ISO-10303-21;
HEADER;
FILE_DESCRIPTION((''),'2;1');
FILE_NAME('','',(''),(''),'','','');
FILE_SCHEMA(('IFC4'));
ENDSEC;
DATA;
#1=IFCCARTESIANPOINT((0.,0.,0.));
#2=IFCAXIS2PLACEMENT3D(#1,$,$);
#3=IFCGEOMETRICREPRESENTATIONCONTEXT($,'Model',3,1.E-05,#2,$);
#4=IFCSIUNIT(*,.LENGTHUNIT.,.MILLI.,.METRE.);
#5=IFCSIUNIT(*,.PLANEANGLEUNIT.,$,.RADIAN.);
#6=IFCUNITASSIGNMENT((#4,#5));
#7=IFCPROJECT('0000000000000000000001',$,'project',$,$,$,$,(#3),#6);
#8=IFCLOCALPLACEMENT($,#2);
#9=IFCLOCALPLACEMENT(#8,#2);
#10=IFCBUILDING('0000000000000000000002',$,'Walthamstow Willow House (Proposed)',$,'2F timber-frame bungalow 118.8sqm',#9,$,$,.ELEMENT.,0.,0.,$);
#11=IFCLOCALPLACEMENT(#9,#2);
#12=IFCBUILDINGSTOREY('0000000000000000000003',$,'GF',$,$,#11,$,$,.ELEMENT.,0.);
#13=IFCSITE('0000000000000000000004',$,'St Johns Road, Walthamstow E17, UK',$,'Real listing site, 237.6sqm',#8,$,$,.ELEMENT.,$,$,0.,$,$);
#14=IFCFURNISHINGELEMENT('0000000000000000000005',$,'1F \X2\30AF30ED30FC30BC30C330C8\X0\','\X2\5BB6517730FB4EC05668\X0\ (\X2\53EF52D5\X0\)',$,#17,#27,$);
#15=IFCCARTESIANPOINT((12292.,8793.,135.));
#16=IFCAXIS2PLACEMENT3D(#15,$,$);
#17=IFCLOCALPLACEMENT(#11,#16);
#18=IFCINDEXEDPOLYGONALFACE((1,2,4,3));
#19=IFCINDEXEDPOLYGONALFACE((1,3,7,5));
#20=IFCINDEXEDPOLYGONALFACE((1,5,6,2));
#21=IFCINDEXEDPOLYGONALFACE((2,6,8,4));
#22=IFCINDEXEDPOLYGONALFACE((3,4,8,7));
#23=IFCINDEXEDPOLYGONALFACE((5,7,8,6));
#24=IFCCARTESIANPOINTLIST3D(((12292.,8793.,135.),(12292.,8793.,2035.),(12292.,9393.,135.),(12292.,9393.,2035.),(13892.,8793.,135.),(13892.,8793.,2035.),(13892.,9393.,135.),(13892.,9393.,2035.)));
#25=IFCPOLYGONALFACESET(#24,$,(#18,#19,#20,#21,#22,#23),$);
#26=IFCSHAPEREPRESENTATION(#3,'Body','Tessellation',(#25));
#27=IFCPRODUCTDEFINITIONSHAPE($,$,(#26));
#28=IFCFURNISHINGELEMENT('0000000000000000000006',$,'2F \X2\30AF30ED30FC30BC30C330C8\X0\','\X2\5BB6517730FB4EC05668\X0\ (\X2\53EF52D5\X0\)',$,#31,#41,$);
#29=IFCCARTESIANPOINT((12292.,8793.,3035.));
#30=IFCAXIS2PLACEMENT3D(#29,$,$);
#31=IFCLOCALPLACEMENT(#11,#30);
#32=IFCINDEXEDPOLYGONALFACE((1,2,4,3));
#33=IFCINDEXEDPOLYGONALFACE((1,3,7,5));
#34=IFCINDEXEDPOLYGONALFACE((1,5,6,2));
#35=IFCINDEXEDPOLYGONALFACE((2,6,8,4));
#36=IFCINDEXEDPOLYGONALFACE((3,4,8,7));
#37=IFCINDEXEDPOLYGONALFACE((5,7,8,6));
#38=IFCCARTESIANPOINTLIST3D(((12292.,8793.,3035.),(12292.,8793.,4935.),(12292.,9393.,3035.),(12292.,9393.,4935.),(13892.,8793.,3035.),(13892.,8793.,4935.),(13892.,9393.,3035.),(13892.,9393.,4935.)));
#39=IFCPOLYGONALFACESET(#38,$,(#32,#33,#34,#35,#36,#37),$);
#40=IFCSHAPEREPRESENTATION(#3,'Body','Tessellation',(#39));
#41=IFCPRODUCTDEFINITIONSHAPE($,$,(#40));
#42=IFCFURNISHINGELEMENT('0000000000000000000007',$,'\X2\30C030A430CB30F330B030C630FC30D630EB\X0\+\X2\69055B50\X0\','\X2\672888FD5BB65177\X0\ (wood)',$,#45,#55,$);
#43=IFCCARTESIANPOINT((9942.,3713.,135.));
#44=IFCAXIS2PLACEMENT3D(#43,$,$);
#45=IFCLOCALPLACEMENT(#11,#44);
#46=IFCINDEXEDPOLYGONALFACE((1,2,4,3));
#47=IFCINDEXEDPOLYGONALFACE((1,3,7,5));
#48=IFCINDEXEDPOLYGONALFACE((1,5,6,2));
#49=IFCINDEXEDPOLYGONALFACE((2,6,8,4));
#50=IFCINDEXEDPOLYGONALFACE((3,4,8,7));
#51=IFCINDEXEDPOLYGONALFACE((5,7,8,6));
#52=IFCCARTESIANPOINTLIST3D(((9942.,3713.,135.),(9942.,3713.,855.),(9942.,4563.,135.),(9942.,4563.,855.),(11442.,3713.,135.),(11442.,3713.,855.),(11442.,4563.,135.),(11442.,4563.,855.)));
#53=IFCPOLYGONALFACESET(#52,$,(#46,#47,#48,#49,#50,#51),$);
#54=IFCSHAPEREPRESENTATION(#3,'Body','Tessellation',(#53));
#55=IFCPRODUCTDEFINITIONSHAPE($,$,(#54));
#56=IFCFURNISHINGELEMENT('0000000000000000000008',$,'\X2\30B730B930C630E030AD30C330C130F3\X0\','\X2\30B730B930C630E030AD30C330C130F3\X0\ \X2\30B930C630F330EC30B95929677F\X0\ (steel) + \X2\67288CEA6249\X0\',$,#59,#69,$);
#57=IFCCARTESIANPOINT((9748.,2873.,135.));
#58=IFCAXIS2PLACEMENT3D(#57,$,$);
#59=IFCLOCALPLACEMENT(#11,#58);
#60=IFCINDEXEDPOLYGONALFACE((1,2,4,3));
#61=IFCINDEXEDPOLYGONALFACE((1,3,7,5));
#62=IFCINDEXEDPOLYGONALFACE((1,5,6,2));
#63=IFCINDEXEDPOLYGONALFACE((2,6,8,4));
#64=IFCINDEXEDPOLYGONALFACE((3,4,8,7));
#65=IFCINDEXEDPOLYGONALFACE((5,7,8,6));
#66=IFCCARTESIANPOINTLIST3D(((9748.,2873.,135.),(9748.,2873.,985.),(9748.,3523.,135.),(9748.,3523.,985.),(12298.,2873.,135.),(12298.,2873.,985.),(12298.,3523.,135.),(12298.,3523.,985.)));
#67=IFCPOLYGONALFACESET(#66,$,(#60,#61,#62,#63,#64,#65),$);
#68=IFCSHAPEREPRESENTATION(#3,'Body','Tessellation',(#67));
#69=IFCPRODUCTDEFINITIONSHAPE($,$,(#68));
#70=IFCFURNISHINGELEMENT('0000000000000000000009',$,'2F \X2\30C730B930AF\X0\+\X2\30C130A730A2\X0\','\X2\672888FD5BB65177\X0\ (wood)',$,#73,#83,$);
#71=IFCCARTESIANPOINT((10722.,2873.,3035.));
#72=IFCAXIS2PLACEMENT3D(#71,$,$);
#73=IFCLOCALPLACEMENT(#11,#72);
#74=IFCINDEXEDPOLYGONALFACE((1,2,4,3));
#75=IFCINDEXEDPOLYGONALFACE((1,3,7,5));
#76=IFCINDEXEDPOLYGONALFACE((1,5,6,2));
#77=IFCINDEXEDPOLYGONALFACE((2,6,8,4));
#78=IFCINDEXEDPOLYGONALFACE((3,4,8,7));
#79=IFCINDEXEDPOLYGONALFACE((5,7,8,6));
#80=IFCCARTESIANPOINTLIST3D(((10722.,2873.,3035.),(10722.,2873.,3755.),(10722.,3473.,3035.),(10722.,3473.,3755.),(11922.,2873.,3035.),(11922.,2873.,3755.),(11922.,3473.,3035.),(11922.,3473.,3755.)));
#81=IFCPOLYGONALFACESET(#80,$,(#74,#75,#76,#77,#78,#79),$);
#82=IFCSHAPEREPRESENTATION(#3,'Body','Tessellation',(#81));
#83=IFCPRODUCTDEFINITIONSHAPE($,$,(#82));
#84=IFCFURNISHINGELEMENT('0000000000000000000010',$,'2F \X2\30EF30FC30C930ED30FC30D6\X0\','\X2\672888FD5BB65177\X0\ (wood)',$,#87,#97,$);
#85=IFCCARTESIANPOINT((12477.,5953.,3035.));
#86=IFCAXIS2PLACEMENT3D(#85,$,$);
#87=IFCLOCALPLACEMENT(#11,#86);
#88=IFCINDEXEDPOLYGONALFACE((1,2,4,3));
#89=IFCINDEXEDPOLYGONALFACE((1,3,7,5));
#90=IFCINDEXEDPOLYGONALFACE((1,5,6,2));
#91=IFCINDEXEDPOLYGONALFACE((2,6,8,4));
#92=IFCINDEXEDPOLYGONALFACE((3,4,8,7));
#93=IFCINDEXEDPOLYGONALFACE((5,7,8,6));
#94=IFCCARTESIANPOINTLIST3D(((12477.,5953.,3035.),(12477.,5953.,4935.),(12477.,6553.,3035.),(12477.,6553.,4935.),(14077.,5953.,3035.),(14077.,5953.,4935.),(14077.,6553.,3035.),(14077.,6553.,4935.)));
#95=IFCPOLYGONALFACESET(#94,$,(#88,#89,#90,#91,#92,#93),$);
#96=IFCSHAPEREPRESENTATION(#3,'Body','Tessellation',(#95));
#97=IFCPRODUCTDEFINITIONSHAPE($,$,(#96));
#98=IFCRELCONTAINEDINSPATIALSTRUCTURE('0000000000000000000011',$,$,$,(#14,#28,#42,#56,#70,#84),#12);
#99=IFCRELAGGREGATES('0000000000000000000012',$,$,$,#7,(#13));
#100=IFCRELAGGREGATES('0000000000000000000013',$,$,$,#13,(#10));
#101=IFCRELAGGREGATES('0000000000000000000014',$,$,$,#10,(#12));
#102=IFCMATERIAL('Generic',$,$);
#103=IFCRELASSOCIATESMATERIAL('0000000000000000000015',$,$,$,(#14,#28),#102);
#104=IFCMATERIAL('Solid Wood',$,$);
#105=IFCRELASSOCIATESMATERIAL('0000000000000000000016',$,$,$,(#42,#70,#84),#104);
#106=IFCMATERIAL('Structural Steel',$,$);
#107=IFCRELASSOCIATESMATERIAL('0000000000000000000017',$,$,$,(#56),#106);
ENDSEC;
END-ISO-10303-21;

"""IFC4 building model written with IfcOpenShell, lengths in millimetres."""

from ifc_helpers import new_model, si_unit, frame, frame_2d, origin, place, context, project, spatial, rectangle, extrude, material, element, save


model = new_model("IFC4")

# Units and contexts
model_context = context("Model", 3, precision=1e-05, world=origin())
ifc_project = project(units=[si_unit("LENGTHUNIT", "METRE", prefix="MILLI"), si_unit("PLANEANGLEUNIT", "RADIAN")], contexts=[model_context])

# Site, building, storey
site_placement = place(None, origin())
site = spatial("IfcSite", under=ifc_project, at=site_placement, Name="St Johns Road, Walthamstow E17, UK", ObjectType="Real listing site, 237.6sqm", CompositionType="ELEMENT", RefElevation=0.0)
building_placement = place(site_placement, origin())
building = spatial("IfcBuilding", under=site, at=building_placement, Name="Walthamstow Willow House (Proposed)", ObjectType="2F timber-frame bungalow 118.8sqm", CompositionType="ELEMENT", ElevationOfRefHeight=0.0, ElevationOfTerrain=0.0)
storey_placement = place(building_placement, origin())
storey = spatial("IfcBuildingStorey", under=building, at=storey_placement, Name="GF", CompositionType="ELEMENT", Elevation=0.0)

# Shared definitions
ifc_material_1 = material(Name="Solid Wood")

# Shared definitions
ifc_material_2 = material(Name="Generic")

# Furnishing elements
furnishing_1_placement = place(storey_placement, frame((12292.0, 8793.0, 135.0)))
element("IfcFurnishingElement", 1, at=furnishing_1_placement, inside=storey, material=ifc_material_2, Name="1F クローゼット", Description="家具・什器 (可動)", context=model_context, shape_type="SweptSolid", body=[
    extrude(rectangle(XDim=1600.0, YDim=600.0, at=frame_2d((800.0, 300.0))), frame((12292.0, 8793.0, 135.0)), (0.0, 0.0, 1.0), 1900.0),
])
furnishing_2_placement = place(storey_placement, frame((12292.0, 8793.0, 3035.0)))
element("IfcFurnishingElement", 2, at=furnishing_2_placement, inside=storey, material=ifc_material_2, Name="2F クローゼット", Description="家具・什器 (可動)", context=model_context, shape_type="SweptSolid", body=[
    extrude(rectangle(XDim=1600.0, YDim=600.0, at=frame_2d((800.0, 300.0))), frame((12292.0, 8793.0, 3035.0)), (0.0, 0.0, 1.0), 1900.0),
])
furnishing_3_placement = place(storey_placement, frame((9942.0, 3713.0, 135.0)))
element("IfcFurnishingElement", 3, at=furnishing_3_placement, inside=storey, material=ifc_material_1, Name="ダイニングテーブル+椅子", Description="木製家具 (wood)", context=model_context, shape_type="SweptSolid", body=[
    extrude(rectangle(XDim=1500.0, YDim=850.0, at=frame_2d((750.0, 425.0))), frame((9942.0, 3713.0, 135.0)), (0.0, 0.0, 1.0), 720.0),
])
ifc_material_3 = material(Name="Structural Steel")
furnishing_4_placement = place(storey_placement, frame((9748.0, 2873.0, 135.0)))
element("IfcFurnishingElement", 4, at=furnishing_4_placement, inside=storey, material=ifc_material_3, Name="システムキッチン", Description="システムキッチン ステンレス天板 (steel) + 木質扉", context=model_context, shape_type="SweptSolid", body=[
    extrude(rectangle(XDim=2550.0, YDim=650.0, at=frame_2d((1275.0, 325.0))), frame((9748.0, 2873.0, 135.0)), (0.0, 0.0, 1.0), 850.0),
])
furnishing_5_placement = place(storey_placement, frame((10722.0, 2873.0, 3035.0)))
element("IfcFurnishingElement", 5, at=furnishing_5_placement, inside=storey, material=ifc_material_1, Name="2F デスク+チェア", Description="木製家具 (wood)", context=model_context, shape_type="SweptSolid", body=[
    extrude(rectangle(XDim=1200.0, YDim=600.0, at=frame_2d((600.0, 300.0))), frame((10722.0, 2873.0, 3035.0)), (0.0, 0.0, 1.0), 720.0),
])
furnishing_6_placement = place(storey_placement, frame((12477.0, 5953.0, 3035.0)))
element("IfcFurnishingElement", 6, at=furnishing_6_placement, inside=storey, material=ifc_material_1, Name="2F ワードローブ", Description="木製家具 (wood)", context=model_context, shape_type="SweptSolid", body=[
    extrude(rectangle(XDim=1600.0, YDim=600.0, at=frame_2d((800.0, 300.0))), frame((12477.0, 5953.0, 3035.0)), (0.0, 0.0, 1.0), 1900.0),
])

save(model, "model.ifc")
